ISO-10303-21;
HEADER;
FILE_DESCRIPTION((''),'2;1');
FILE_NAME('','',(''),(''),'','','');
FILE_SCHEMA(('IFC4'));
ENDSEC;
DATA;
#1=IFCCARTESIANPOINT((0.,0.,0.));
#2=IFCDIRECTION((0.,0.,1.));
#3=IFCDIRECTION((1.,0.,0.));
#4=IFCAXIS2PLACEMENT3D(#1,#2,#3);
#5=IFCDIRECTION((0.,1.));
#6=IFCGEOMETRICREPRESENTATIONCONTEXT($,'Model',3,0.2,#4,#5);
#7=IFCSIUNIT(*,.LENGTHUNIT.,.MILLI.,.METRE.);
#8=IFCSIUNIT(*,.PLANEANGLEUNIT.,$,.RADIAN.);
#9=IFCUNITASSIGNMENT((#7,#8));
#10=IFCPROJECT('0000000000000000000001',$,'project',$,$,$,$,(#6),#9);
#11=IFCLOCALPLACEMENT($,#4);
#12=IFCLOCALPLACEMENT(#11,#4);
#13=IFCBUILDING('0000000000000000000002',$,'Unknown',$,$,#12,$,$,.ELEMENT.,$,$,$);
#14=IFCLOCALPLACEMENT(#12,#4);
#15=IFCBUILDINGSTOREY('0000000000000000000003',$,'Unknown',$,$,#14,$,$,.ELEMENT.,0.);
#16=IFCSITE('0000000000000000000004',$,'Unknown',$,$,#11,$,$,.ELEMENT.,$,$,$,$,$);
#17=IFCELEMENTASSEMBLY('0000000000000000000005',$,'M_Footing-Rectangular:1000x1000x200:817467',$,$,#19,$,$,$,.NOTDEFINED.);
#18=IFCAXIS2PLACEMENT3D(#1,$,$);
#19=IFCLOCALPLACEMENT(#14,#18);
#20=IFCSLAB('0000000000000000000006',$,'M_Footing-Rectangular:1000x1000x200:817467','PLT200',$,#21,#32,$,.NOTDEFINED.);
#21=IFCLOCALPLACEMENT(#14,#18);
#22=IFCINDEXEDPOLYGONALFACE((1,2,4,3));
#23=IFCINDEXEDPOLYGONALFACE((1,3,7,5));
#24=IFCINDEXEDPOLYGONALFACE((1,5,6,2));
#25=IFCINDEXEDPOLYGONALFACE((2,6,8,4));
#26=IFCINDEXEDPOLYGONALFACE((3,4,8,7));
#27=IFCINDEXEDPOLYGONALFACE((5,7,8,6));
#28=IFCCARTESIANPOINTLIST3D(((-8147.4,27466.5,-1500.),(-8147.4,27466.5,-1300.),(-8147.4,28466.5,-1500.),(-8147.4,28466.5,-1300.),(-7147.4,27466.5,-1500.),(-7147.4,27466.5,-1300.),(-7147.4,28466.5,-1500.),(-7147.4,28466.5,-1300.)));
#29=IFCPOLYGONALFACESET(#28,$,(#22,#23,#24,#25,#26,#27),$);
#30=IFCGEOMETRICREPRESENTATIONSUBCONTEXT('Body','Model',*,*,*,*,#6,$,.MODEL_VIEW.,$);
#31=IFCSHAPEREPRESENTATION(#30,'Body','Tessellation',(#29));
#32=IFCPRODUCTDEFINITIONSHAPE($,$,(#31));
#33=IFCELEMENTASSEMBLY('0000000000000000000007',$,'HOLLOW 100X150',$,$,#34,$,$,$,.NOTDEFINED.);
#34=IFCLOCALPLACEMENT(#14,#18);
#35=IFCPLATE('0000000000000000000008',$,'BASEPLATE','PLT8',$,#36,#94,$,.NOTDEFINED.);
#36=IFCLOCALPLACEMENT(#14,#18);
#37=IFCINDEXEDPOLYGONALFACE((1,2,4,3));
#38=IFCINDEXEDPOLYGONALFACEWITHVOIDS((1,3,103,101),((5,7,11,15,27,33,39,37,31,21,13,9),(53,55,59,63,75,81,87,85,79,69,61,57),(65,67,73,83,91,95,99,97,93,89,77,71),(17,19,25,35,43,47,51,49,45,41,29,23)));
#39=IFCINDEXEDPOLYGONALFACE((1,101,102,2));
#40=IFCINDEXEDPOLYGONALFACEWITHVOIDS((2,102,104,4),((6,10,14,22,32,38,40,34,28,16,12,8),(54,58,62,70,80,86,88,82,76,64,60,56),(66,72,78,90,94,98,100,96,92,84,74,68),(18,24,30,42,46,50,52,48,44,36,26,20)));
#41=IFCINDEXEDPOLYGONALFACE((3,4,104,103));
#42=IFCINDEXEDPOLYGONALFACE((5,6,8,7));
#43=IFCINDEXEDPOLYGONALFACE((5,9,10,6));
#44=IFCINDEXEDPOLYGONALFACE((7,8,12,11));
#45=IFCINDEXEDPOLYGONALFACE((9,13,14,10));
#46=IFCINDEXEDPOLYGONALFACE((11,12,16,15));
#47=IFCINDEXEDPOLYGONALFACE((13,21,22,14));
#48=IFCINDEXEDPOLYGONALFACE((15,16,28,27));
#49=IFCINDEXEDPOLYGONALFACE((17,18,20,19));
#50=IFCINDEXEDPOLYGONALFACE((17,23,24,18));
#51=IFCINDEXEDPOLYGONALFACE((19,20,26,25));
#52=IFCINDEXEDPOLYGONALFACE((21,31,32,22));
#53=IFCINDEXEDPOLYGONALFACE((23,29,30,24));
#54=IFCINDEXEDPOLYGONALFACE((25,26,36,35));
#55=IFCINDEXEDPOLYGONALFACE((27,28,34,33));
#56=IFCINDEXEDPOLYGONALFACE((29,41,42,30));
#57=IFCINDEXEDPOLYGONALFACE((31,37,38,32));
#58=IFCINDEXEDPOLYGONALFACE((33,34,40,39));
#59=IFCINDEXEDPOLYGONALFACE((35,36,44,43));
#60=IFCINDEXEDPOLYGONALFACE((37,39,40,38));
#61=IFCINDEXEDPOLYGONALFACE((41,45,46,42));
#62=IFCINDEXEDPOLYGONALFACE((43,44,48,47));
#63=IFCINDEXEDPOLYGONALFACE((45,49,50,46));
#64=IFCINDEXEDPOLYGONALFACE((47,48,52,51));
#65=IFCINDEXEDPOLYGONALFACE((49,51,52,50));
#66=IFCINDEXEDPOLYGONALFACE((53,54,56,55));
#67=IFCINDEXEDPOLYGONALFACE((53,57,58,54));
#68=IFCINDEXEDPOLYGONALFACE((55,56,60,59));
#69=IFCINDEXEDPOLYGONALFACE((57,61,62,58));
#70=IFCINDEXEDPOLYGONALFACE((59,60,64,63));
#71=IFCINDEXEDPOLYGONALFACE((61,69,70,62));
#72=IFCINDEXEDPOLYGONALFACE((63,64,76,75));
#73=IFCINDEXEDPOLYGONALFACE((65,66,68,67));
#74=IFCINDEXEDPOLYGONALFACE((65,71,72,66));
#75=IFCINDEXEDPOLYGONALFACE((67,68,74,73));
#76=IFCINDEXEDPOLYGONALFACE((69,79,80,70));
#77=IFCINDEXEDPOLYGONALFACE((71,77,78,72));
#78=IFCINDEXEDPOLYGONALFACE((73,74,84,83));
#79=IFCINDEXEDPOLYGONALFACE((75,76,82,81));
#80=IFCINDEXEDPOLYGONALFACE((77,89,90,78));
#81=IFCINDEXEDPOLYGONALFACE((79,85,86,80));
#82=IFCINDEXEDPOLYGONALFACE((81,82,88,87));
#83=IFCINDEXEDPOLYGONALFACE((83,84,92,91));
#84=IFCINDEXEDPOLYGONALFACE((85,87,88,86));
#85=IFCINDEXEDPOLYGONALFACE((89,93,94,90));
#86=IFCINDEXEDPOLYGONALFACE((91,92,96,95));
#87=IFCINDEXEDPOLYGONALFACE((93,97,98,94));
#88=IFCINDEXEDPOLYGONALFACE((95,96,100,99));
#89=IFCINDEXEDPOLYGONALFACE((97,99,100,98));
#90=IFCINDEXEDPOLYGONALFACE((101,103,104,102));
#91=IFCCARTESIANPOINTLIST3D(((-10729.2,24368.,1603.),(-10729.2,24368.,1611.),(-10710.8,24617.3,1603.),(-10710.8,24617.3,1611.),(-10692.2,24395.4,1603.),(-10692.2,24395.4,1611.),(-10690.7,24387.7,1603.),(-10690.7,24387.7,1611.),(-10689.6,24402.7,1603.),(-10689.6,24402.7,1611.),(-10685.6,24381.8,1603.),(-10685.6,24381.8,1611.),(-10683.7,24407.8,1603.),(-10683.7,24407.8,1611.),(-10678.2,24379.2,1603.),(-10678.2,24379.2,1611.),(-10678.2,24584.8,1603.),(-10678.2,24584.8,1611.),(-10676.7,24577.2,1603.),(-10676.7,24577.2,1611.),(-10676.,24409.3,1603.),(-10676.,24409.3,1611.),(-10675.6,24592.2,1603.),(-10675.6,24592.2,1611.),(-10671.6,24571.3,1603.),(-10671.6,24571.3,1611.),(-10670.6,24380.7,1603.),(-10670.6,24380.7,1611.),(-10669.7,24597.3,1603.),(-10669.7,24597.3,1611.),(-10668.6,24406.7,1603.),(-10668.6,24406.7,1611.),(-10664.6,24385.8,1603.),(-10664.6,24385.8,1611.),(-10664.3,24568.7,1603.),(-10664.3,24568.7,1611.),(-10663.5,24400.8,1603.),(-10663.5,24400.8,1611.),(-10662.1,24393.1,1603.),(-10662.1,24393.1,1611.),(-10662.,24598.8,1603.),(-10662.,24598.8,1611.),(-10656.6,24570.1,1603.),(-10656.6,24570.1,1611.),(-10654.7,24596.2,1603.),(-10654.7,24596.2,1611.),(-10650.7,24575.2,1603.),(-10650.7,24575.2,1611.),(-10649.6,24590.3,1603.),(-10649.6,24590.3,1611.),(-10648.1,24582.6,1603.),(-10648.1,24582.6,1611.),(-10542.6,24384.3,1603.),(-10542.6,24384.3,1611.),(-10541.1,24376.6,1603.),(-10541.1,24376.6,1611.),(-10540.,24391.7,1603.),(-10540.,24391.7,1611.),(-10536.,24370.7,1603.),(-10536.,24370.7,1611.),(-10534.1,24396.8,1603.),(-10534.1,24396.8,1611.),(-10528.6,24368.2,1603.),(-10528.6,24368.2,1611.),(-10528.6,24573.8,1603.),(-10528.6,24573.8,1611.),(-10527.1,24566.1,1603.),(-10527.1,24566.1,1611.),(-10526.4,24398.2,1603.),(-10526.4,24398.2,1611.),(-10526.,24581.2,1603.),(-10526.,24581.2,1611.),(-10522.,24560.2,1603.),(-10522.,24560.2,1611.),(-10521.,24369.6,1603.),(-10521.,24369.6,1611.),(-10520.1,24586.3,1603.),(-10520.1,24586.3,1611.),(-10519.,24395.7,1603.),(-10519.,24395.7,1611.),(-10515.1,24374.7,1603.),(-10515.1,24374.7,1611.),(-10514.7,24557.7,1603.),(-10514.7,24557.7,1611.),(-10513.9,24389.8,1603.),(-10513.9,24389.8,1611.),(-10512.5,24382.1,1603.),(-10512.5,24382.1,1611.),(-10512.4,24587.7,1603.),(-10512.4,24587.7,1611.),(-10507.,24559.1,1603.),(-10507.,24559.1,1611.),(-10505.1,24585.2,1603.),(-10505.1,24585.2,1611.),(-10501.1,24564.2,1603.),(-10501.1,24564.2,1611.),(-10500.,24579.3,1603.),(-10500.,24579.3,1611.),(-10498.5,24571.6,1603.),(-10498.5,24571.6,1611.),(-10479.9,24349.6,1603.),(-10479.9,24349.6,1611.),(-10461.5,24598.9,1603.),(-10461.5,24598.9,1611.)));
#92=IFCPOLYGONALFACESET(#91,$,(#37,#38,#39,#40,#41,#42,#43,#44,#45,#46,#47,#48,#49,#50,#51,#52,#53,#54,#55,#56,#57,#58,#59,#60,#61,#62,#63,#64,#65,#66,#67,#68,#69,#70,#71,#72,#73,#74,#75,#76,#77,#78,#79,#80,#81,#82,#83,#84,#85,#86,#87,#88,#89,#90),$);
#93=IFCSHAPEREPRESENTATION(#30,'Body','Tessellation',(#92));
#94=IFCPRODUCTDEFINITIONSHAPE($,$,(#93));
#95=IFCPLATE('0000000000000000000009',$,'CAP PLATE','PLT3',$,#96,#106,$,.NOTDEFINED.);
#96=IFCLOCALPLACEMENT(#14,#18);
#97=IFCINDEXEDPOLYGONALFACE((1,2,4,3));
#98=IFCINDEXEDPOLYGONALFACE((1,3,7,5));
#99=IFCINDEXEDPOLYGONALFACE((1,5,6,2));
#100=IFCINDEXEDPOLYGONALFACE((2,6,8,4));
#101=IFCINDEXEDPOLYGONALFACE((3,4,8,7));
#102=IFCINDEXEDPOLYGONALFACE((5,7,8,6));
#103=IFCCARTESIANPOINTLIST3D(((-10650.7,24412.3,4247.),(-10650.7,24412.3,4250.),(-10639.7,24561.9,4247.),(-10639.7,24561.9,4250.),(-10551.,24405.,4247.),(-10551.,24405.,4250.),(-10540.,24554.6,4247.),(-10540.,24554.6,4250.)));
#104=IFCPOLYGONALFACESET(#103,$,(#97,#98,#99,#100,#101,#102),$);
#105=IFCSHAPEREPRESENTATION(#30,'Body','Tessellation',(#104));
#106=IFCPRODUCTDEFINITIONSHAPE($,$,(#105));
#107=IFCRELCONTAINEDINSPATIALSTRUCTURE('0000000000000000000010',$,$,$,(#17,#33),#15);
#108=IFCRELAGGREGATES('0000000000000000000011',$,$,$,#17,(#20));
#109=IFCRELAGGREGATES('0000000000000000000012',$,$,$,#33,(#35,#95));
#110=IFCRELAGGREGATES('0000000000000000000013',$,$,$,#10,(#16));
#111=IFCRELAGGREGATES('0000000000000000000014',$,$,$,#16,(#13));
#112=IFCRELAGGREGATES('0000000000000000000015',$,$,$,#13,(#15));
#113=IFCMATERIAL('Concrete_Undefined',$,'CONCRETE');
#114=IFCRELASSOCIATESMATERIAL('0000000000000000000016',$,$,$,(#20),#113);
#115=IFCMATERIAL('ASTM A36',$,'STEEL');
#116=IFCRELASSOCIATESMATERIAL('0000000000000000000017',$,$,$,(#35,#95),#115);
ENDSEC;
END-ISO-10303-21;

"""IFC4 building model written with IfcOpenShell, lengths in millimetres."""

from ifc_helpers import new_model, si_unit, direction, frame, origin_with_axes, place, context, subcontext, project, spatial, line, indexed_curve, outline, extrude, material, element, aggregate, save


model = new_model("IFC4")

# Units and contexts
model_context = context("Model", 3, precision=0.2, world=origin_with_axes(), true_north=direction((0.0, 1.0)))
body_context = subcontext(model_context, "Body", "Model", "MODEL_VIEW")
ifc_project = project(units=[si_unit("LENGTHUNIT", "METRE", prefix="MILLI"), si_unit("PLANEANGLEUNIT", "RADIAN")], contexts=[model_context])

# Site, building, storey
site_placement = place(None, origin_with_axes())
site = spatial("IfcSite", under=ifc_project, at=site_placement, Name="Unknown", CompositionType="ELEMENT")
building_placement = place(site_placement, origin_with_axes())
building = spatial("IfcBuilding", under=site, at=building_placement, Name="Unknown", CompositionType="ELEMENT")
storey_placement = place(building_placement, origin_with_axes())
storey = spatial("IfcBuildingStorey", under=building, at=storey_placement, Name="Unknown", CompositionType="ELEMENT", Elevation=0.0)

# Shared definitions
ifc_material_1 = material(Name="ASTM A36", Category="STEEL")

# Element assembly, slab
assembly_1_placement = place(storey_placement, frame((-8147.4, 28466.5, -1400.0), z_axis=(0.0, 0.0, -1.0), x_axis=(1.0, 0.0, 0.0)))
assembly_1 = element("IfcElementAssembly", 1, at=assembly_1_placement, inside=storey, Name="M_Footing-Rectangular:1000x1000x200:817467", PredefinedType="NOTDEFINED")
ifc_material_2 = material(Name="Concrete_Undefined", Category="CONCRETE")
slab_placement = place(assembly_1_placement, origin_with_axes())
slab = element("IfcSlab", 2, at=slab_placement, material=ifc_material_2, Name="M_Footing-Rectangular:1000x1000x200:817467", Description="PLT200", PredefinedType="NOTDEFINED", context=body_context, shape_type="SolidModel", body=[
    extrude(outline(indexed_curve([(0.0, 0.0), (1000.0, 0.0), (1000.0, 1000.0), (0.0, 1000.0)], segments=[line(1, 2, 3, 4, 1)])), frame((0.0, 0.0, 100.0), z_axis=(0.0, 0.0, 1.0), x_axis=(1.0, 0.0, 0.0)), (0.0, 0.0, -1.0), 200.0),
])
aggregate(assembly_1, [slab])

# Element assembly, plates, voiding features
assembly_2_placement = place(storey_placement, frame((-10595.3, 24483.5, 1512.9), z_axis=(-0.073569, -0.99729, 0.0), x_axis=(0.0, 0.0, 1.0)))
assembly_2 = element("IfcElementAssembly", 3, at=assembly_2_placement, inside=storey, Name="HOLLOW 100X150", PredefinedType="NOTDEFINED")
plate_1_placement = place(assembly_2_placement, frame((94.1, 125.0, -125.0), z_axis=(-1.0, 0.0, 0.0), x_axis=(0.0, -1.0, 0.0)))
plate_1 = element("IfcPlate", 4, at=plate_1_placement, material=ifc_material_1, Name="BASEPLATE", Description="PLT8", PredefinedType="NOTDEFINED", context=body_context, shape_type="SolidModel", body=[
    extrude(outline(indexed_curve([(0.0, 0.0), (250.0, 0.0), (250.0, 250.0), (0.0, 250.0)], segments=[line(1, 2, 3, 4, 1)])), frame((0.0, 0.0, 4.0), z_axis=(0.0, 0.0, 1.0), x_axis=(1.0, 0.0, 0.0)), (0.0, 0.0, -1.0), 8.0),
])
voiding_feature_1_placement = place(plate_1_placement, frame((200.0, 30.0, 4.5), z_axis=(-1.0, 0.0, 0.0), x_axis=(0.0, 0.0, -1.0)))
element("IfcVoidingFeature", 5, at=voiding_feature_1_placement, cuts=plate_1, Name="BEAM", PredefinedType="HOLE", context=body_context, shape_type="SolidModel", body=[
    extrude(outline(indexed_curve([(15.1, 0.0), (13.1, 7.5), (7.5, 13.1), (0.0, 15.1), (-7.5, 13.1), (-13.1, 7.5), (-15.1, 0.0), (-13.1, -7.5), (-7.5, -13.1), (0.0, -15.1), (7.5, -13.1), (13.1, -7.5)], segments=[line(1, 2, 3, 4, 5, 6, 7, 8, 9, 10, 11, 12, 1)])), frame((0.0, 0.0, 0.0), z_axis=(-1.0, 0.0, 0.0), x_axis=(0.0, 0.0, 1.0)), (0.0, 0.0, -1.0), 9.0),
])
voiding_feature_2_placement = place(plate_1_placement, frame((50.0, 30.0, 4.5), z_axis=(-1.0, 0.0, 0.0), x_axis=(0.0, 0.0, -1.0)))
element("IfcVoidingFeature", 6, at=voiding_feature_2_placement, cuts=plate_1, Name="BEAM", PredefinedType="HOLE", context=body_context, shape_type="SolidModel", body=[
    extrude(outline(indexed_curve([(15.1, 0.0), (13.1, 7.5), (7.5, 13.1), (0.0, 15.1), (-7.5, 13.1), (-13.1, 7.5), (-15.1, 0.0), (-13.1, -7.5), (-7.5, -13.1), (0.0, -15.1), (7.5, -13.1), (13.1, -7.5)], segments=[line(1, 2, 3, 4, 5, 6, 7, 8, 9, 10, 11, 12, 1)])), frame((0.0, 0.0, 0.0), z_axis=(-1.0, 0.0, 0.0), x_axis=(0.0, 0.0, 1.0)), (0.0, 0.0, -1.0), 9.0),
])
voiding_feature_3_placement = place(plate_1_placement, frame((200.0, 220.0, 4.5), z_axis=(-1.0, 0.0, 0.0), x_axis=(0.0, 0.0, -1.0)))
element("IfcVoidingFeature", 7, at=voiding_feature_3_placement, cuts=plate_1, Name="BEAM", PredefinedType="HOLE", context=body_context, shape_type="SolidModel", body=[
    extrude(outline(indexed_curve([(15.1, 0.0), (13.1, 7.5), (7.5, 13.1), (0.0, 15.1), (-7.5, 13.1), (-13.1, 7.5), (-15.1, 0.0), (-13.1, -7.5), (-7.5, -13.1), (0.0, -15.1), (7.5, -13.1), (13.1, -7.5)], segments=[line(1, 2, 3, 4, 5, 6, 7, 8, 9, 10, 11, 12, 1)])), frame((0.0, 0.0, 0.0), z_axis=(-1.0, 0.0, 0.0), x_axis=(0.0, 0.0, 1.0)), (0.0, 0.0, -1.0), 9.0),
])
voiding_feature_4_placement = place(plate_1_placement, frame((50.0, 220.0, 4.5), z_axis=(-1.0, 0.0, 0.0), x_axis=(0.0, 0.0, -1.0)))
element("IfcVoidingFeature", 8, at=voiding_feature_4_placement, cuts=plate_1, Name="BEAM", PredefinedType="HOLE", context=body_context, shape_type="SolidModel", body=[
    extrude(outline(indexed_curve([(15.1, 0.0), (13.1, 7.5), (7.5, 13.1), (0.0, 15.1), (-7.5, 13.1), (-13.1, 7.5), (-15.1, 0.0), (-13.1, -7.5), (-7.5, -13.1), (0.0, -15.1), (7.5, -13.1), (13.1, -7.5)], segments=[line(1, 2, 3, 4, 5, 6, 7, 8, 9, 10, 11, 12, 1)])), frame((0.0, 0.0, 0.0), z_axis=(-1.0, 0.0, 0.0), x_axis=(0.0, 0.0, 1.0)), (0.0, 0.0, -1.0), 9.0),
])
plate_2_placement = place(assembly_2_placement, frame((2735.6, 50.0, 75.0), z_axis=(1.0, 0.0, 0.0), x_axis=(0.0, -1.0, 0.0)))
plate_2 = element("IfcPlate", 9, at=plate_2_placement, material=ifc_material_1, Name="CAP PLATE", Description="PLT3", PredefinedType="NOTDEFINED", context=body_context, shape_type="SolidModel", body=[
    extrude(outline(indexed_curve([(0.0, 0.0), (100.0, 0.0), (100.0, 150.0), (0.0, 150.0)], segments=[line(1, 2, 3, 4, 1)])), frame((0.0, 0.0, 1.5), z_axis=(0.0, 0.0, 1.0), x_axis=(1.0, 0.0, 0.0)), (0.0, 0.0, -1.0), 3.0),
])
aggregate(assembly_2, [plate_1, plate_2])

save(model, "model.ifc")
